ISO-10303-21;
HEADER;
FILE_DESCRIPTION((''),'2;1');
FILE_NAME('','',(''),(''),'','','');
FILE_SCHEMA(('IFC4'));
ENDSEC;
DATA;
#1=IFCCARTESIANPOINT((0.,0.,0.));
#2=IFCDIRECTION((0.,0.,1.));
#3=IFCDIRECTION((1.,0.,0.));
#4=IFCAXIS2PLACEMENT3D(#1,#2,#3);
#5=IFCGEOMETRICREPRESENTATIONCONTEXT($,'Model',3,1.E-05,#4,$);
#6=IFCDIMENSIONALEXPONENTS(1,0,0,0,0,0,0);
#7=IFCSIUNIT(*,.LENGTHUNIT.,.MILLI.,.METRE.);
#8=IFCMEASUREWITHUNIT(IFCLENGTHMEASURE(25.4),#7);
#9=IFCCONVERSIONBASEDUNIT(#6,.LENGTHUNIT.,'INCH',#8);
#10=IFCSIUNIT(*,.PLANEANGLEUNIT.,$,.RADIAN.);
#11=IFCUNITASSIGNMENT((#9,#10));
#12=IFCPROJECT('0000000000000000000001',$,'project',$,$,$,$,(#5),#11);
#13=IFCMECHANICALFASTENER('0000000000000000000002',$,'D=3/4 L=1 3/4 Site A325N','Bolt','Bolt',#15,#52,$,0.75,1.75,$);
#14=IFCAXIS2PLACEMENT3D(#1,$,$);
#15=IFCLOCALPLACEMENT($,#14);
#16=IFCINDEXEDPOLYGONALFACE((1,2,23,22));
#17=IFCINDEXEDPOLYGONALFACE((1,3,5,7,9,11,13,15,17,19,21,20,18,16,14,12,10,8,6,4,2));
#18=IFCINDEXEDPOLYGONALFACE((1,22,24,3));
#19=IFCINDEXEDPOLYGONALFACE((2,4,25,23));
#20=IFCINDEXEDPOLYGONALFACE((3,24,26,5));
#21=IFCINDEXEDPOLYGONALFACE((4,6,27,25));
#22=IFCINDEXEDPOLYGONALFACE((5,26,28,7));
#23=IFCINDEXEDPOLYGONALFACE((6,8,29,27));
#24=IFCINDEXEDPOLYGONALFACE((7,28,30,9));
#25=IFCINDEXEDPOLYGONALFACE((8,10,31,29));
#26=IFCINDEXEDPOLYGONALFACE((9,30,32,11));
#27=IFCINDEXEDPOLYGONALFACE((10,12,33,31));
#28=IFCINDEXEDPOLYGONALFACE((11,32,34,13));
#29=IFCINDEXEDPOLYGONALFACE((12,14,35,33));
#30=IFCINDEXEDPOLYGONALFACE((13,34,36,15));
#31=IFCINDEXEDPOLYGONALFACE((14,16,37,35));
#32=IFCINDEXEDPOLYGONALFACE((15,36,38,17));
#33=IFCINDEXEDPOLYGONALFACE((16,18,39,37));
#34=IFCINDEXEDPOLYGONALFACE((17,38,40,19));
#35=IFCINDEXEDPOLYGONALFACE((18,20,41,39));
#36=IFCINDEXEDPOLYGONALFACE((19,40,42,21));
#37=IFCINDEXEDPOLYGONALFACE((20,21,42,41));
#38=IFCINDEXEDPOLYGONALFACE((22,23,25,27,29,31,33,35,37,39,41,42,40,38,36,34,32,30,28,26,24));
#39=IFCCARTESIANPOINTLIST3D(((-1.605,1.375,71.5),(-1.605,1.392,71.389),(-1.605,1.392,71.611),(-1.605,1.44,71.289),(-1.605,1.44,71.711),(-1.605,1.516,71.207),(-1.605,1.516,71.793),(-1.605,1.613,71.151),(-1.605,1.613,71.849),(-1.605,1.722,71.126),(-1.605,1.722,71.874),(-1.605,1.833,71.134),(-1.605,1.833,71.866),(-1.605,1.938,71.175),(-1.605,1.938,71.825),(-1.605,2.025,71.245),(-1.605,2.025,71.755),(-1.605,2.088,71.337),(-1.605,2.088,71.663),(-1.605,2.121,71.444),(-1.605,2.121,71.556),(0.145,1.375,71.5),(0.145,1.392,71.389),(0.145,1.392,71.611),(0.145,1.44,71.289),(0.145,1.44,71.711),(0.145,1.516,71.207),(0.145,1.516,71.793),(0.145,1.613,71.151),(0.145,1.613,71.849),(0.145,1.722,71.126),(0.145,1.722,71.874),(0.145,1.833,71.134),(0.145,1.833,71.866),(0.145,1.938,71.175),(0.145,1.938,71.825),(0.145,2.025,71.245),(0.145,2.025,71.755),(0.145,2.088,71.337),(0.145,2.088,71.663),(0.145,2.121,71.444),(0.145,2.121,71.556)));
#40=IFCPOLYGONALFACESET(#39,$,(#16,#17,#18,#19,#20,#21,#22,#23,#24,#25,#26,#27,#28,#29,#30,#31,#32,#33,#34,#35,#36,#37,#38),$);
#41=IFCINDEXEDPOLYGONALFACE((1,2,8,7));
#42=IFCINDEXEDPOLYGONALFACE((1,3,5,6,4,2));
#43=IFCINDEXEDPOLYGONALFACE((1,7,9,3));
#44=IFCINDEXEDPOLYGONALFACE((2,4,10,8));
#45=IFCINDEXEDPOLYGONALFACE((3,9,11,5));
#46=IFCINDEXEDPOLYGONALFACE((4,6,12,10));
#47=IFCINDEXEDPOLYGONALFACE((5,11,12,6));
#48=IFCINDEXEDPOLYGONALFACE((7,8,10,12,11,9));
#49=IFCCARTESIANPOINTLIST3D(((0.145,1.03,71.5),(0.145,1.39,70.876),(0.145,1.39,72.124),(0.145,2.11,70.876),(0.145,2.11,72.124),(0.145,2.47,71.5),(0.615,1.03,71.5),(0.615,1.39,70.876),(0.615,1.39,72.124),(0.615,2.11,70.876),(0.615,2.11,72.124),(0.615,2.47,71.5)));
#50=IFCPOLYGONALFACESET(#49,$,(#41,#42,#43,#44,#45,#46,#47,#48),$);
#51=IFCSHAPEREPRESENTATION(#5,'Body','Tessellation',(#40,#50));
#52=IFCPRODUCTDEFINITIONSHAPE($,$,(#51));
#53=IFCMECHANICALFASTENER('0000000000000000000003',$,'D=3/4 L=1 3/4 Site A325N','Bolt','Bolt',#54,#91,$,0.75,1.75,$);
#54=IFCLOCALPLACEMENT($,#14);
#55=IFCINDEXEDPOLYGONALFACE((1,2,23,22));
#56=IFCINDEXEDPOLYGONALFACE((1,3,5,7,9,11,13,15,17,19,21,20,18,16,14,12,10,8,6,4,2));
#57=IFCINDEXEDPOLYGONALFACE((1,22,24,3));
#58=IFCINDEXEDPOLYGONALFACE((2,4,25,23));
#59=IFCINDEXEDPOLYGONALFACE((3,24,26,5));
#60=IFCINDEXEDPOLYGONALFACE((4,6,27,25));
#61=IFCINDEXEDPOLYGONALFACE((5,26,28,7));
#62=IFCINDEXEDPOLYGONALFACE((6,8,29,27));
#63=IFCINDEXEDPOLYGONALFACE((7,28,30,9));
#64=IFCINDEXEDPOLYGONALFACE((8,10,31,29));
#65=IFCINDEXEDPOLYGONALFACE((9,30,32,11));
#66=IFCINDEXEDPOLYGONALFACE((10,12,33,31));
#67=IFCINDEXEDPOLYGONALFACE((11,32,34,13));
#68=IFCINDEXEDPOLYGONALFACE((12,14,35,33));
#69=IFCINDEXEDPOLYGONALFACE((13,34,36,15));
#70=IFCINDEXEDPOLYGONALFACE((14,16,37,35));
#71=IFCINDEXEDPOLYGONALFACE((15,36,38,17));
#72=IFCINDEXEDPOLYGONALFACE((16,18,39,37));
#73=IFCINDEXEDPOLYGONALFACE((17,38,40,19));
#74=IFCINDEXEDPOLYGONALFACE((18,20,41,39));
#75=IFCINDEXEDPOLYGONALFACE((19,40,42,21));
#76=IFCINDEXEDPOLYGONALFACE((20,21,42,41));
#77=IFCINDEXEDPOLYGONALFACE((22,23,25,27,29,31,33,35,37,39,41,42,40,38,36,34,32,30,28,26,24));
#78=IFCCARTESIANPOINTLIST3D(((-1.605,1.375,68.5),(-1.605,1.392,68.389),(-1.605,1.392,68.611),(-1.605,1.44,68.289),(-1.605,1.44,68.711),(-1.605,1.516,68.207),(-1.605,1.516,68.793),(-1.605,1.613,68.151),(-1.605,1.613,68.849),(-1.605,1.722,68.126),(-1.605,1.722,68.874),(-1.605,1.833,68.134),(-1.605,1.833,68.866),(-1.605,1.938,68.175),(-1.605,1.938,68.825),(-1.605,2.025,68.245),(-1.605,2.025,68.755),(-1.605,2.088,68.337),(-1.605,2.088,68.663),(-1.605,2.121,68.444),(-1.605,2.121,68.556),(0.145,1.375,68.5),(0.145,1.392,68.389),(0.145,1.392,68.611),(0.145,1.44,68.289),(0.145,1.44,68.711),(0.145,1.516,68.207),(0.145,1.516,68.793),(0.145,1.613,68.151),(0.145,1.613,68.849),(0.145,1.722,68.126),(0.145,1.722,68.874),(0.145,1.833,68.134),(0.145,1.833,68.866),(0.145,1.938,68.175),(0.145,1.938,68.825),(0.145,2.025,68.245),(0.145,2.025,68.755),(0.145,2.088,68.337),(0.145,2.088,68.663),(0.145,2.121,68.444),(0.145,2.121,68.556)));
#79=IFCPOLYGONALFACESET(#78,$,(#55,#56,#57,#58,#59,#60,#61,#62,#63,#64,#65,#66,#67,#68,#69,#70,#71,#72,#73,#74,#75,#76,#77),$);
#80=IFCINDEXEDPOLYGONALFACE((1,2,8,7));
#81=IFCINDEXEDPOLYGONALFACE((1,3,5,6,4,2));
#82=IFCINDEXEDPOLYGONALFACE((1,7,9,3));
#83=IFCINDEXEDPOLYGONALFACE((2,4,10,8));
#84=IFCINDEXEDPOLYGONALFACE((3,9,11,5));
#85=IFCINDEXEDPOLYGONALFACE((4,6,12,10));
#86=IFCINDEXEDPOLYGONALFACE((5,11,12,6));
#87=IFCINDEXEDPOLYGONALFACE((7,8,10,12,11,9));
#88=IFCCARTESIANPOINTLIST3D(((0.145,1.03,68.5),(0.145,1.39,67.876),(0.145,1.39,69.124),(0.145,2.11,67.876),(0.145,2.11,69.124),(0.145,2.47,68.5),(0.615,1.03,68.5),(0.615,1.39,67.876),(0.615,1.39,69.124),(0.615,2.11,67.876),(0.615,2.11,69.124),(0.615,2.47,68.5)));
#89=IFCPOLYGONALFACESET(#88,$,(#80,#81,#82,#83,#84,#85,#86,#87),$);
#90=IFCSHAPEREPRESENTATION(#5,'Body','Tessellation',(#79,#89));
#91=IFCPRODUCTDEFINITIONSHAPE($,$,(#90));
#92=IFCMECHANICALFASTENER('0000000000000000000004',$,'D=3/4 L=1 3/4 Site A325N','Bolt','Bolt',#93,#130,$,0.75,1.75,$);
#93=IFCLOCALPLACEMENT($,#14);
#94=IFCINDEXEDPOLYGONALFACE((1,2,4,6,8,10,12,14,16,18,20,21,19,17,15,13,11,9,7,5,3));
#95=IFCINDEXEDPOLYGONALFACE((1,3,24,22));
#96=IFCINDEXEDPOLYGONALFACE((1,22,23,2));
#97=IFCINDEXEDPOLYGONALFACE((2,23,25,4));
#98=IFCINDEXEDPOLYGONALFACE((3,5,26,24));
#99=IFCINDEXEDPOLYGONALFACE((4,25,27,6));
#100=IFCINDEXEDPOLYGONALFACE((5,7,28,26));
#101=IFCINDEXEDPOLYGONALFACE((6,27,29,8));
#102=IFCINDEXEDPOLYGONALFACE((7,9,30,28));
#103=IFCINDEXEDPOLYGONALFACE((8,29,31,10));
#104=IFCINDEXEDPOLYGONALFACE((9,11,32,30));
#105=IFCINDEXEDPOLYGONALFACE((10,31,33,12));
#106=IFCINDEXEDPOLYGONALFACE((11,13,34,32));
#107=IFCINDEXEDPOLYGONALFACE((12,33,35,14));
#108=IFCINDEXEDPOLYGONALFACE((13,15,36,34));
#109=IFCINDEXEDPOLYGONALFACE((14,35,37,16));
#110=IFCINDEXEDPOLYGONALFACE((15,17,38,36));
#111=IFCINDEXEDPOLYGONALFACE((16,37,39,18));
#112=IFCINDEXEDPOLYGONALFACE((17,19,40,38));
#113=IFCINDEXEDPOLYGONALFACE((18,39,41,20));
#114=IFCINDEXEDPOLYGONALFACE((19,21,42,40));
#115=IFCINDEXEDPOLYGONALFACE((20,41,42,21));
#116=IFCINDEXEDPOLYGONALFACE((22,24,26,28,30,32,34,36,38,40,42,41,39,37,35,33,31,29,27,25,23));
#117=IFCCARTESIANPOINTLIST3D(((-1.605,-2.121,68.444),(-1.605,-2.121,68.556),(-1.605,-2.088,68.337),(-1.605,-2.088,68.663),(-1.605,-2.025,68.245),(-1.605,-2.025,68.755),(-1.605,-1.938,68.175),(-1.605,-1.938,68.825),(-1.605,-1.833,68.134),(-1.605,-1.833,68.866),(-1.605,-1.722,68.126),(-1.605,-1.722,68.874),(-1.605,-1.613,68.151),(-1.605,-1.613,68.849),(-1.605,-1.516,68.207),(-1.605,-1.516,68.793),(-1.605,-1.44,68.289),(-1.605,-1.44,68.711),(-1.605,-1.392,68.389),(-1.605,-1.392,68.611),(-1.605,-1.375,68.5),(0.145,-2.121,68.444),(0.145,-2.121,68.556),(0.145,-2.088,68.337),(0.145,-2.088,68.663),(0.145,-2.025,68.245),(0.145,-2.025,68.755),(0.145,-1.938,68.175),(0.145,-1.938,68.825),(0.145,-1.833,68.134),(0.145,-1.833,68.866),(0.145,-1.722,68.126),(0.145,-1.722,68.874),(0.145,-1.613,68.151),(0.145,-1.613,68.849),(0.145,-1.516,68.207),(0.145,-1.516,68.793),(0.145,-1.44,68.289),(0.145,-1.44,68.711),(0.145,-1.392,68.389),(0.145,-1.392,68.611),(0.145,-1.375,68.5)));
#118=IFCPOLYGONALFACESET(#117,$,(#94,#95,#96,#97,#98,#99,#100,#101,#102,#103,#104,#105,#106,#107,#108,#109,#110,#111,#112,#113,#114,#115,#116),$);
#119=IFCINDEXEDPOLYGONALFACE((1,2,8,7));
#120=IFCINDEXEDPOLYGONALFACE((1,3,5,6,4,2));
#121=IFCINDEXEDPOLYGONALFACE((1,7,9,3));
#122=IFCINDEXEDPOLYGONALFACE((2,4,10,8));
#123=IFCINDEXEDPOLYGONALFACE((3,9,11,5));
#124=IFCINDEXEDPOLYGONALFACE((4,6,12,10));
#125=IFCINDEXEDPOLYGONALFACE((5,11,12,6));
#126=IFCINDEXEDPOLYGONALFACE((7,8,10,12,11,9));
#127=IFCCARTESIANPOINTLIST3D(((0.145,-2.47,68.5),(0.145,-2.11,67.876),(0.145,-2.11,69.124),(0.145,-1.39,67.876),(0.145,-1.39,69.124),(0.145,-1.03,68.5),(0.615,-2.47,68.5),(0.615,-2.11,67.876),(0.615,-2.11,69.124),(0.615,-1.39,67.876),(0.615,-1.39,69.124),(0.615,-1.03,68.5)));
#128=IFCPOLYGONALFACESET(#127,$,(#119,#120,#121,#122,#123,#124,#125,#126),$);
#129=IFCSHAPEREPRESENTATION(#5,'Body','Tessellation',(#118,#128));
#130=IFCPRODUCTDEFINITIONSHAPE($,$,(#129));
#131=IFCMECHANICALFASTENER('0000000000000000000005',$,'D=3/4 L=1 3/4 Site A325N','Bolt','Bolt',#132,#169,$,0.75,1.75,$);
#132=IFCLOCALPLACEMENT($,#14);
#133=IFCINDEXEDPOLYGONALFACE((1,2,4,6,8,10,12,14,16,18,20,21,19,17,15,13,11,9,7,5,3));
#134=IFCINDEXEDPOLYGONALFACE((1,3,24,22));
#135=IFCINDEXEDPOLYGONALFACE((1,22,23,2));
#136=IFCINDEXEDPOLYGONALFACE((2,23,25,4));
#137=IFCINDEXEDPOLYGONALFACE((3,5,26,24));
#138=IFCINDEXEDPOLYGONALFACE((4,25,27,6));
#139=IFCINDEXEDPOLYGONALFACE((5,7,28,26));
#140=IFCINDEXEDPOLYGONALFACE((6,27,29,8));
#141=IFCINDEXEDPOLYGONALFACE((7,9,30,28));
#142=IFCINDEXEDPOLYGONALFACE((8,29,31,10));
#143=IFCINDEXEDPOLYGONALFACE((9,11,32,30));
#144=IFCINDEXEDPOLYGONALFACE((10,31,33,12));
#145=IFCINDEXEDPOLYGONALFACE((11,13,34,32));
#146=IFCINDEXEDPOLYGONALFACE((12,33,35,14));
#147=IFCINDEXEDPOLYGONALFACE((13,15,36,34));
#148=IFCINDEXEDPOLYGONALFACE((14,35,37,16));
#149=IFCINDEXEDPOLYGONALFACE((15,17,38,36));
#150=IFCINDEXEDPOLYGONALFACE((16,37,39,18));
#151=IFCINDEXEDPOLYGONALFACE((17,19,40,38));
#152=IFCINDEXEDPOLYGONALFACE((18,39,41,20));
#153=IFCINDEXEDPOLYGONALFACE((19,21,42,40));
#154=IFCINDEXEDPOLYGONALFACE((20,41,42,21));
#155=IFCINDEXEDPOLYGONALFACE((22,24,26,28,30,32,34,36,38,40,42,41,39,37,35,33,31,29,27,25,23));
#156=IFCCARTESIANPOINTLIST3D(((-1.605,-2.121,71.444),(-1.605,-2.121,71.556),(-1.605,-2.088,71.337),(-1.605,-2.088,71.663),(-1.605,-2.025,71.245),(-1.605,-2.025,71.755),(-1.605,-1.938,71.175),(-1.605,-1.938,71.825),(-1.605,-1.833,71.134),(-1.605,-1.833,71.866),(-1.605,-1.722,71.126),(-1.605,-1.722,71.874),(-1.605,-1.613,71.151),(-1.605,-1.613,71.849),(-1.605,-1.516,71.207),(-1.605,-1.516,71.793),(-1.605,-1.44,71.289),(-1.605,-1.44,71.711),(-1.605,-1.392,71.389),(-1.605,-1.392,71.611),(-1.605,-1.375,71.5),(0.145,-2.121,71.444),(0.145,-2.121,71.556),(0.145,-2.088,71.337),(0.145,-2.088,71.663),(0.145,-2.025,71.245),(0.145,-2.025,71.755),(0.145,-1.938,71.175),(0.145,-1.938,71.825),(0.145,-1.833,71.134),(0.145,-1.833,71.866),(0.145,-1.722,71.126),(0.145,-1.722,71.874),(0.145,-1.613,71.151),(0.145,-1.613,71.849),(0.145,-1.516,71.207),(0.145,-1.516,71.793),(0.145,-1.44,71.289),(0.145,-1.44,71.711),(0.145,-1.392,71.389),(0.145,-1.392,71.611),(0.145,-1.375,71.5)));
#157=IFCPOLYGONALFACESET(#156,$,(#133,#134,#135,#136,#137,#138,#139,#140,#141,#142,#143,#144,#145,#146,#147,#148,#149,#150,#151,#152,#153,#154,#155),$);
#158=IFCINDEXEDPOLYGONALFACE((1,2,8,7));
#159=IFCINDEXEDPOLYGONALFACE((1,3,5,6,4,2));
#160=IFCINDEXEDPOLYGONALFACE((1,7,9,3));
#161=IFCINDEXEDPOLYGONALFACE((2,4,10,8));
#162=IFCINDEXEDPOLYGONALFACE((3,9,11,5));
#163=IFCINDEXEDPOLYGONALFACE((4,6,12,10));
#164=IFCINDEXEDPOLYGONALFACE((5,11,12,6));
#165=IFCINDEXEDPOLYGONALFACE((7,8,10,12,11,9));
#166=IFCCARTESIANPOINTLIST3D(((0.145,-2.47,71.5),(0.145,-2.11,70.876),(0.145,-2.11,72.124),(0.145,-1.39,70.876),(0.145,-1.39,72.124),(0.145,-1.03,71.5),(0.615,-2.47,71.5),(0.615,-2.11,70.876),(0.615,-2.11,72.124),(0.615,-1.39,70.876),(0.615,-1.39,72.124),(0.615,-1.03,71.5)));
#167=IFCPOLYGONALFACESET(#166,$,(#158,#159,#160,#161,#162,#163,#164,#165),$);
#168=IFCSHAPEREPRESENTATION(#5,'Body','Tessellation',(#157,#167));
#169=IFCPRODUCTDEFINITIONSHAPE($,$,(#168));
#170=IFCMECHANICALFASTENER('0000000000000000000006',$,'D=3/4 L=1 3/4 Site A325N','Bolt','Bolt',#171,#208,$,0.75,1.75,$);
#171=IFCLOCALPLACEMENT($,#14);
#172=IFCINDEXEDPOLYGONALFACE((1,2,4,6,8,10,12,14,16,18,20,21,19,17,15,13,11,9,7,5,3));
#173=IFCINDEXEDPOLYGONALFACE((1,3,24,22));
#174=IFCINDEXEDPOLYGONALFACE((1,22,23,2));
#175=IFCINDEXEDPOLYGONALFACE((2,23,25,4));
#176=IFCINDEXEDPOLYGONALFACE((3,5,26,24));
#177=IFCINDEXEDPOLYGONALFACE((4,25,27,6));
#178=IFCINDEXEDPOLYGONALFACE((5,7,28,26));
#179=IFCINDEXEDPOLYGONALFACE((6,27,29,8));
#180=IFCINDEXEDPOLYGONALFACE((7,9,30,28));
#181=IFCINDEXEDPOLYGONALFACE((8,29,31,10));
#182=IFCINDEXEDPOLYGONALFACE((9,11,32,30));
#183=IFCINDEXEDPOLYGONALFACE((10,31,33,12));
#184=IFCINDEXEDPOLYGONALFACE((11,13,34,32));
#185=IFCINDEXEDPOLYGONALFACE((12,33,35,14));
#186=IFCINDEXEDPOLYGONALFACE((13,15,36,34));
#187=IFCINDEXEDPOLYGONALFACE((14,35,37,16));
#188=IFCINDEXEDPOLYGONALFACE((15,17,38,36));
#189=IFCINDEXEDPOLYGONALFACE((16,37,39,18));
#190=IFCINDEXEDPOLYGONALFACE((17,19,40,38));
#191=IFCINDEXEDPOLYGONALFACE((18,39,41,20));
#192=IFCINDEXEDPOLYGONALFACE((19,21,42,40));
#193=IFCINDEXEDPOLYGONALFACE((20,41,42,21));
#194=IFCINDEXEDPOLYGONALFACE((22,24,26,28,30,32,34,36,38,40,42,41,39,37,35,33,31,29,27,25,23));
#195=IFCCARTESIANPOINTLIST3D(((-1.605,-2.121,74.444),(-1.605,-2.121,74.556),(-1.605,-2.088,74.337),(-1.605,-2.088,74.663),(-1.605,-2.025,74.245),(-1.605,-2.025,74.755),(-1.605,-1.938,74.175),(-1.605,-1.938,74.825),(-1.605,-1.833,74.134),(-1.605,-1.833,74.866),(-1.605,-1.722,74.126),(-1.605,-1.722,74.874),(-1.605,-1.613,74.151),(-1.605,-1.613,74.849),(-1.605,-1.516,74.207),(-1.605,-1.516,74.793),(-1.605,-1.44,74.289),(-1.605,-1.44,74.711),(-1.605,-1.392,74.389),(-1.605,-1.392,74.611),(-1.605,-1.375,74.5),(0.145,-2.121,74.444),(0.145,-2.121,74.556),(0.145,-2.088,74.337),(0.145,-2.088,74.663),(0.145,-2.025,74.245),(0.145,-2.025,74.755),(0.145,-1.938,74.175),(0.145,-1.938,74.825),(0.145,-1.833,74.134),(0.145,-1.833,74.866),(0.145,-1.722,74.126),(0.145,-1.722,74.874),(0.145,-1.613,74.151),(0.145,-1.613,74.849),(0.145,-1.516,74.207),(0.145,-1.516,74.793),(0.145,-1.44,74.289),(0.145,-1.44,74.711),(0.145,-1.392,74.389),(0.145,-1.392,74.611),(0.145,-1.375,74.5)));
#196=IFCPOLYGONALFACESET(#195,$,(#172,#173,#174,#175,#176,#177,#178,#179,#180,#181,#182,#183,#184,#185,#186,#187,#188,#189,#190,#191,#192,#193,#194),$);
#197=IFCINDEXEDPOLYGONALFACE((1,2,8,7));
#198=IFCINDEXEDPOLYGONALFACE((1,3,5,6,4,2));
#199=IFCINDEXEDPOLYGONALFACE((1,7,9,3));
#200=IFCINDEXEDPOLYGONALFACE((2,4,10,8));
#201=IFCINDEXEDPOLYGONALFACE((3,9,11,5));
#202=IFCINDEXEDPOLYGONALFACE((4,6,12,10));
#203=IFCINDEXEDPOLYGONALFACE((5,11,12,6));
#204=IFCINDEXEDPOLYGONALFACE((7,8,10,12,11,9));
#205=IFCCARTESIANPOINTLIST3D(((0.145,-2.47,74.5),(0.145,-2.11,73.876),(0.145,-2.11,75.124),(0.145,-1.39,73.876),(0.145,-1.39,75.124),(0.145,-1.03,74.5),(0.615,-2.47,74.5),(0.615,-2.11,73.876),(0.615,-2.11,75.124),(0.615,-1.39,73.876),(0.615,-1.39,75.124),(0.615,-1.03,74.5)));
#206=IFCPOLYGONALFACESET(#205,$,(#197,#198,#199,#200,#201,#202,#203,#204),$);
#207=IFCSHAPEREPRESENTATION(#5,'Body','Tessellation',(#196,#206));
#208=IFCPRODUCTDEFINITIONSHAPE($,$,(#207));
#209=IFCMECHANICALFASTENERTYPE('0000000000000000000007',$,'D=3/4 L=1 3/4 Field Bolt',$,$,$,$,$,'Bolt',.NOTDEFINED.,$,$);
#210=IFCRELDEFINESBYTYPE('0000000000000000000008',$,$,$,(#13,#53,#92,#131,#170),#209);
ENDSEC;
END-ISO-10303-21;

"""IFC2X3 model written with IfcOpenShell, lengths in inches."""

from ifc_helpers import new_model, entity, si_unit, converted_unit, frame, origin_with_axes, origin_2d_with_axis, place, context, project, polyline, circle, outline, extrude, source, transform, mapped, type_object, type_shapes, element, save


model = new_model("IFC2X3")

# Units and contexts
model_context = context("Model", 3, precision=1e-05, world=origin_with_axes())
ifc_project = project(units=[converted_unit("LENGTHUNIT", "INCH", entity("IfcLengthMeasure", 25.4), si_unit("LENGTHUNIT", "METRE", prefix="MILLI"), dimensions=[1, 0, 0, 0, 0, 0, 0]), si_unit("PLANEANGLEUNIT", "RADIAN")], contexts=[model_context])

# Mechanical fasteners
mechanical_fastener_type_1 = type_object("IfcMechanicalFastenerType", Name="D=3/4 L=1 3/4 Field Bolt", ElementType="Bolt")
shared_shape_1 = source(origin_with_axes(), model_context, "Body", "SweptSolid", [
    extrude(circle(Radius=0.375, at=origin_2d_with_axis()), frame((0.0, 0.0, 0.0), z_axis=(1.0, 0.0, 0.0), x_axis=(0.0, 1.0, 0.0)), (0.0, 0.0, 1.0), 1.75),
    extrude(outline(polyline([(-0.72, 0.0), (-0.36, 0.624), (0.36, 0.624), (0.72, 0.0), (0.36, -0.624), (-0.36, -0.624), (-0.72, 0.0)])), frame((0.0, 0.0, 0.0), z_axis=(1.0, 0.0, 0.0), x_axis=(0.0, 1.0, 0.0)), (0.0, 0.0, -1.0), 0.47),
])
type_shapes(mechanical_fastener_type_1, [shared_shape_1])
placement_1 = place(None, origin_with_axes())
placement_2 = place(placement_1, origin_with_axes())
placement_3 = place(placement_2, frame((0.0, 0.0, 80.0), z_axis=(0.0, 0.0, 1.0), x_axis=(-1.0, 0.0, 0.0)))
placement_4 = place(placement_3, frame((-0.145, -1.75, -11.5), z_axis=(0.0, 0.0, 1.0), x_axis=(1.0, 0.0, 0.0)))
for number, where, z_axis, x_axis, name in (
    (1, (0.0, 0.0, 3.0), (0.0, 0.0, 1.0), (1.0, 0.0, 0.0), "D=3/4 L=1 3/4 Site A325N"),
    (2, (0.0, 0.0, 0.0), (0.0, 0.0, 1.0), (1.0, 0.0, 0.0), "D=3/4 L=1 3/4 Site A325N"),
):
    element("IfcMechanicalFastener", number, at=place(placement_4, frame(where, z_axis=z_axis, x_axis=x_axis)), type_object=mechanical_fastener_type_1, Name=name, Description="Bolt", ObjectType="Bolt", NominalDiameter=0.75, NominalLength=1.75, context=model_context, shape_type="MappedRepresentation", body=[
        mapped(shared_shape_1, transform((0.0, 0.0, 0.0), scale=1.0)),
    ])
placement_5 = place(placement_3, frame((-0.145, 1.75, -5.5), z_axis=(0.0, 0.0, -1.0), x_axis=(1.0, 0.0, 0.0)))
for number, where, z_axis, x_axis, name in (
    (3, (0.0, 0.0, 6.0), (0.0, 0.0, 1.0), (1.0, 0.0, 0.0), "D=3/4 L=1 3/4 Site A325N"),
    (4, (0.0, 0.0, 3.0), (0.0, 0.0, 1.0), (1.0, 0.0, 0.0), "D=3/4 L=1 3/4 Site A325N"),
    (5, (0.0, 0.0, 0.0), (0.0, 0.0, 1.0), (1.0, 0.0, 0.0), "D=3/4 L=1 3/4 Site A325N"),
):
    element("IfcMechanicalFastener", number, at=place(placement_5, frame(where, z_axis=z_axis, x_axis=x_axis)), type_object=mechanical_fastener_type_1, Name=name, Description="Bolt", ObjectType="Bolt", NominalDiameter=0.75, NominalLength=1.75, context=model_context, shape_type="MappedRepresentation", body=[
        mapped(shared_shape_1, transform((0.0, 0.0, 0.0), scale=1.0)),
    ])

save(model, "model.ifc")
